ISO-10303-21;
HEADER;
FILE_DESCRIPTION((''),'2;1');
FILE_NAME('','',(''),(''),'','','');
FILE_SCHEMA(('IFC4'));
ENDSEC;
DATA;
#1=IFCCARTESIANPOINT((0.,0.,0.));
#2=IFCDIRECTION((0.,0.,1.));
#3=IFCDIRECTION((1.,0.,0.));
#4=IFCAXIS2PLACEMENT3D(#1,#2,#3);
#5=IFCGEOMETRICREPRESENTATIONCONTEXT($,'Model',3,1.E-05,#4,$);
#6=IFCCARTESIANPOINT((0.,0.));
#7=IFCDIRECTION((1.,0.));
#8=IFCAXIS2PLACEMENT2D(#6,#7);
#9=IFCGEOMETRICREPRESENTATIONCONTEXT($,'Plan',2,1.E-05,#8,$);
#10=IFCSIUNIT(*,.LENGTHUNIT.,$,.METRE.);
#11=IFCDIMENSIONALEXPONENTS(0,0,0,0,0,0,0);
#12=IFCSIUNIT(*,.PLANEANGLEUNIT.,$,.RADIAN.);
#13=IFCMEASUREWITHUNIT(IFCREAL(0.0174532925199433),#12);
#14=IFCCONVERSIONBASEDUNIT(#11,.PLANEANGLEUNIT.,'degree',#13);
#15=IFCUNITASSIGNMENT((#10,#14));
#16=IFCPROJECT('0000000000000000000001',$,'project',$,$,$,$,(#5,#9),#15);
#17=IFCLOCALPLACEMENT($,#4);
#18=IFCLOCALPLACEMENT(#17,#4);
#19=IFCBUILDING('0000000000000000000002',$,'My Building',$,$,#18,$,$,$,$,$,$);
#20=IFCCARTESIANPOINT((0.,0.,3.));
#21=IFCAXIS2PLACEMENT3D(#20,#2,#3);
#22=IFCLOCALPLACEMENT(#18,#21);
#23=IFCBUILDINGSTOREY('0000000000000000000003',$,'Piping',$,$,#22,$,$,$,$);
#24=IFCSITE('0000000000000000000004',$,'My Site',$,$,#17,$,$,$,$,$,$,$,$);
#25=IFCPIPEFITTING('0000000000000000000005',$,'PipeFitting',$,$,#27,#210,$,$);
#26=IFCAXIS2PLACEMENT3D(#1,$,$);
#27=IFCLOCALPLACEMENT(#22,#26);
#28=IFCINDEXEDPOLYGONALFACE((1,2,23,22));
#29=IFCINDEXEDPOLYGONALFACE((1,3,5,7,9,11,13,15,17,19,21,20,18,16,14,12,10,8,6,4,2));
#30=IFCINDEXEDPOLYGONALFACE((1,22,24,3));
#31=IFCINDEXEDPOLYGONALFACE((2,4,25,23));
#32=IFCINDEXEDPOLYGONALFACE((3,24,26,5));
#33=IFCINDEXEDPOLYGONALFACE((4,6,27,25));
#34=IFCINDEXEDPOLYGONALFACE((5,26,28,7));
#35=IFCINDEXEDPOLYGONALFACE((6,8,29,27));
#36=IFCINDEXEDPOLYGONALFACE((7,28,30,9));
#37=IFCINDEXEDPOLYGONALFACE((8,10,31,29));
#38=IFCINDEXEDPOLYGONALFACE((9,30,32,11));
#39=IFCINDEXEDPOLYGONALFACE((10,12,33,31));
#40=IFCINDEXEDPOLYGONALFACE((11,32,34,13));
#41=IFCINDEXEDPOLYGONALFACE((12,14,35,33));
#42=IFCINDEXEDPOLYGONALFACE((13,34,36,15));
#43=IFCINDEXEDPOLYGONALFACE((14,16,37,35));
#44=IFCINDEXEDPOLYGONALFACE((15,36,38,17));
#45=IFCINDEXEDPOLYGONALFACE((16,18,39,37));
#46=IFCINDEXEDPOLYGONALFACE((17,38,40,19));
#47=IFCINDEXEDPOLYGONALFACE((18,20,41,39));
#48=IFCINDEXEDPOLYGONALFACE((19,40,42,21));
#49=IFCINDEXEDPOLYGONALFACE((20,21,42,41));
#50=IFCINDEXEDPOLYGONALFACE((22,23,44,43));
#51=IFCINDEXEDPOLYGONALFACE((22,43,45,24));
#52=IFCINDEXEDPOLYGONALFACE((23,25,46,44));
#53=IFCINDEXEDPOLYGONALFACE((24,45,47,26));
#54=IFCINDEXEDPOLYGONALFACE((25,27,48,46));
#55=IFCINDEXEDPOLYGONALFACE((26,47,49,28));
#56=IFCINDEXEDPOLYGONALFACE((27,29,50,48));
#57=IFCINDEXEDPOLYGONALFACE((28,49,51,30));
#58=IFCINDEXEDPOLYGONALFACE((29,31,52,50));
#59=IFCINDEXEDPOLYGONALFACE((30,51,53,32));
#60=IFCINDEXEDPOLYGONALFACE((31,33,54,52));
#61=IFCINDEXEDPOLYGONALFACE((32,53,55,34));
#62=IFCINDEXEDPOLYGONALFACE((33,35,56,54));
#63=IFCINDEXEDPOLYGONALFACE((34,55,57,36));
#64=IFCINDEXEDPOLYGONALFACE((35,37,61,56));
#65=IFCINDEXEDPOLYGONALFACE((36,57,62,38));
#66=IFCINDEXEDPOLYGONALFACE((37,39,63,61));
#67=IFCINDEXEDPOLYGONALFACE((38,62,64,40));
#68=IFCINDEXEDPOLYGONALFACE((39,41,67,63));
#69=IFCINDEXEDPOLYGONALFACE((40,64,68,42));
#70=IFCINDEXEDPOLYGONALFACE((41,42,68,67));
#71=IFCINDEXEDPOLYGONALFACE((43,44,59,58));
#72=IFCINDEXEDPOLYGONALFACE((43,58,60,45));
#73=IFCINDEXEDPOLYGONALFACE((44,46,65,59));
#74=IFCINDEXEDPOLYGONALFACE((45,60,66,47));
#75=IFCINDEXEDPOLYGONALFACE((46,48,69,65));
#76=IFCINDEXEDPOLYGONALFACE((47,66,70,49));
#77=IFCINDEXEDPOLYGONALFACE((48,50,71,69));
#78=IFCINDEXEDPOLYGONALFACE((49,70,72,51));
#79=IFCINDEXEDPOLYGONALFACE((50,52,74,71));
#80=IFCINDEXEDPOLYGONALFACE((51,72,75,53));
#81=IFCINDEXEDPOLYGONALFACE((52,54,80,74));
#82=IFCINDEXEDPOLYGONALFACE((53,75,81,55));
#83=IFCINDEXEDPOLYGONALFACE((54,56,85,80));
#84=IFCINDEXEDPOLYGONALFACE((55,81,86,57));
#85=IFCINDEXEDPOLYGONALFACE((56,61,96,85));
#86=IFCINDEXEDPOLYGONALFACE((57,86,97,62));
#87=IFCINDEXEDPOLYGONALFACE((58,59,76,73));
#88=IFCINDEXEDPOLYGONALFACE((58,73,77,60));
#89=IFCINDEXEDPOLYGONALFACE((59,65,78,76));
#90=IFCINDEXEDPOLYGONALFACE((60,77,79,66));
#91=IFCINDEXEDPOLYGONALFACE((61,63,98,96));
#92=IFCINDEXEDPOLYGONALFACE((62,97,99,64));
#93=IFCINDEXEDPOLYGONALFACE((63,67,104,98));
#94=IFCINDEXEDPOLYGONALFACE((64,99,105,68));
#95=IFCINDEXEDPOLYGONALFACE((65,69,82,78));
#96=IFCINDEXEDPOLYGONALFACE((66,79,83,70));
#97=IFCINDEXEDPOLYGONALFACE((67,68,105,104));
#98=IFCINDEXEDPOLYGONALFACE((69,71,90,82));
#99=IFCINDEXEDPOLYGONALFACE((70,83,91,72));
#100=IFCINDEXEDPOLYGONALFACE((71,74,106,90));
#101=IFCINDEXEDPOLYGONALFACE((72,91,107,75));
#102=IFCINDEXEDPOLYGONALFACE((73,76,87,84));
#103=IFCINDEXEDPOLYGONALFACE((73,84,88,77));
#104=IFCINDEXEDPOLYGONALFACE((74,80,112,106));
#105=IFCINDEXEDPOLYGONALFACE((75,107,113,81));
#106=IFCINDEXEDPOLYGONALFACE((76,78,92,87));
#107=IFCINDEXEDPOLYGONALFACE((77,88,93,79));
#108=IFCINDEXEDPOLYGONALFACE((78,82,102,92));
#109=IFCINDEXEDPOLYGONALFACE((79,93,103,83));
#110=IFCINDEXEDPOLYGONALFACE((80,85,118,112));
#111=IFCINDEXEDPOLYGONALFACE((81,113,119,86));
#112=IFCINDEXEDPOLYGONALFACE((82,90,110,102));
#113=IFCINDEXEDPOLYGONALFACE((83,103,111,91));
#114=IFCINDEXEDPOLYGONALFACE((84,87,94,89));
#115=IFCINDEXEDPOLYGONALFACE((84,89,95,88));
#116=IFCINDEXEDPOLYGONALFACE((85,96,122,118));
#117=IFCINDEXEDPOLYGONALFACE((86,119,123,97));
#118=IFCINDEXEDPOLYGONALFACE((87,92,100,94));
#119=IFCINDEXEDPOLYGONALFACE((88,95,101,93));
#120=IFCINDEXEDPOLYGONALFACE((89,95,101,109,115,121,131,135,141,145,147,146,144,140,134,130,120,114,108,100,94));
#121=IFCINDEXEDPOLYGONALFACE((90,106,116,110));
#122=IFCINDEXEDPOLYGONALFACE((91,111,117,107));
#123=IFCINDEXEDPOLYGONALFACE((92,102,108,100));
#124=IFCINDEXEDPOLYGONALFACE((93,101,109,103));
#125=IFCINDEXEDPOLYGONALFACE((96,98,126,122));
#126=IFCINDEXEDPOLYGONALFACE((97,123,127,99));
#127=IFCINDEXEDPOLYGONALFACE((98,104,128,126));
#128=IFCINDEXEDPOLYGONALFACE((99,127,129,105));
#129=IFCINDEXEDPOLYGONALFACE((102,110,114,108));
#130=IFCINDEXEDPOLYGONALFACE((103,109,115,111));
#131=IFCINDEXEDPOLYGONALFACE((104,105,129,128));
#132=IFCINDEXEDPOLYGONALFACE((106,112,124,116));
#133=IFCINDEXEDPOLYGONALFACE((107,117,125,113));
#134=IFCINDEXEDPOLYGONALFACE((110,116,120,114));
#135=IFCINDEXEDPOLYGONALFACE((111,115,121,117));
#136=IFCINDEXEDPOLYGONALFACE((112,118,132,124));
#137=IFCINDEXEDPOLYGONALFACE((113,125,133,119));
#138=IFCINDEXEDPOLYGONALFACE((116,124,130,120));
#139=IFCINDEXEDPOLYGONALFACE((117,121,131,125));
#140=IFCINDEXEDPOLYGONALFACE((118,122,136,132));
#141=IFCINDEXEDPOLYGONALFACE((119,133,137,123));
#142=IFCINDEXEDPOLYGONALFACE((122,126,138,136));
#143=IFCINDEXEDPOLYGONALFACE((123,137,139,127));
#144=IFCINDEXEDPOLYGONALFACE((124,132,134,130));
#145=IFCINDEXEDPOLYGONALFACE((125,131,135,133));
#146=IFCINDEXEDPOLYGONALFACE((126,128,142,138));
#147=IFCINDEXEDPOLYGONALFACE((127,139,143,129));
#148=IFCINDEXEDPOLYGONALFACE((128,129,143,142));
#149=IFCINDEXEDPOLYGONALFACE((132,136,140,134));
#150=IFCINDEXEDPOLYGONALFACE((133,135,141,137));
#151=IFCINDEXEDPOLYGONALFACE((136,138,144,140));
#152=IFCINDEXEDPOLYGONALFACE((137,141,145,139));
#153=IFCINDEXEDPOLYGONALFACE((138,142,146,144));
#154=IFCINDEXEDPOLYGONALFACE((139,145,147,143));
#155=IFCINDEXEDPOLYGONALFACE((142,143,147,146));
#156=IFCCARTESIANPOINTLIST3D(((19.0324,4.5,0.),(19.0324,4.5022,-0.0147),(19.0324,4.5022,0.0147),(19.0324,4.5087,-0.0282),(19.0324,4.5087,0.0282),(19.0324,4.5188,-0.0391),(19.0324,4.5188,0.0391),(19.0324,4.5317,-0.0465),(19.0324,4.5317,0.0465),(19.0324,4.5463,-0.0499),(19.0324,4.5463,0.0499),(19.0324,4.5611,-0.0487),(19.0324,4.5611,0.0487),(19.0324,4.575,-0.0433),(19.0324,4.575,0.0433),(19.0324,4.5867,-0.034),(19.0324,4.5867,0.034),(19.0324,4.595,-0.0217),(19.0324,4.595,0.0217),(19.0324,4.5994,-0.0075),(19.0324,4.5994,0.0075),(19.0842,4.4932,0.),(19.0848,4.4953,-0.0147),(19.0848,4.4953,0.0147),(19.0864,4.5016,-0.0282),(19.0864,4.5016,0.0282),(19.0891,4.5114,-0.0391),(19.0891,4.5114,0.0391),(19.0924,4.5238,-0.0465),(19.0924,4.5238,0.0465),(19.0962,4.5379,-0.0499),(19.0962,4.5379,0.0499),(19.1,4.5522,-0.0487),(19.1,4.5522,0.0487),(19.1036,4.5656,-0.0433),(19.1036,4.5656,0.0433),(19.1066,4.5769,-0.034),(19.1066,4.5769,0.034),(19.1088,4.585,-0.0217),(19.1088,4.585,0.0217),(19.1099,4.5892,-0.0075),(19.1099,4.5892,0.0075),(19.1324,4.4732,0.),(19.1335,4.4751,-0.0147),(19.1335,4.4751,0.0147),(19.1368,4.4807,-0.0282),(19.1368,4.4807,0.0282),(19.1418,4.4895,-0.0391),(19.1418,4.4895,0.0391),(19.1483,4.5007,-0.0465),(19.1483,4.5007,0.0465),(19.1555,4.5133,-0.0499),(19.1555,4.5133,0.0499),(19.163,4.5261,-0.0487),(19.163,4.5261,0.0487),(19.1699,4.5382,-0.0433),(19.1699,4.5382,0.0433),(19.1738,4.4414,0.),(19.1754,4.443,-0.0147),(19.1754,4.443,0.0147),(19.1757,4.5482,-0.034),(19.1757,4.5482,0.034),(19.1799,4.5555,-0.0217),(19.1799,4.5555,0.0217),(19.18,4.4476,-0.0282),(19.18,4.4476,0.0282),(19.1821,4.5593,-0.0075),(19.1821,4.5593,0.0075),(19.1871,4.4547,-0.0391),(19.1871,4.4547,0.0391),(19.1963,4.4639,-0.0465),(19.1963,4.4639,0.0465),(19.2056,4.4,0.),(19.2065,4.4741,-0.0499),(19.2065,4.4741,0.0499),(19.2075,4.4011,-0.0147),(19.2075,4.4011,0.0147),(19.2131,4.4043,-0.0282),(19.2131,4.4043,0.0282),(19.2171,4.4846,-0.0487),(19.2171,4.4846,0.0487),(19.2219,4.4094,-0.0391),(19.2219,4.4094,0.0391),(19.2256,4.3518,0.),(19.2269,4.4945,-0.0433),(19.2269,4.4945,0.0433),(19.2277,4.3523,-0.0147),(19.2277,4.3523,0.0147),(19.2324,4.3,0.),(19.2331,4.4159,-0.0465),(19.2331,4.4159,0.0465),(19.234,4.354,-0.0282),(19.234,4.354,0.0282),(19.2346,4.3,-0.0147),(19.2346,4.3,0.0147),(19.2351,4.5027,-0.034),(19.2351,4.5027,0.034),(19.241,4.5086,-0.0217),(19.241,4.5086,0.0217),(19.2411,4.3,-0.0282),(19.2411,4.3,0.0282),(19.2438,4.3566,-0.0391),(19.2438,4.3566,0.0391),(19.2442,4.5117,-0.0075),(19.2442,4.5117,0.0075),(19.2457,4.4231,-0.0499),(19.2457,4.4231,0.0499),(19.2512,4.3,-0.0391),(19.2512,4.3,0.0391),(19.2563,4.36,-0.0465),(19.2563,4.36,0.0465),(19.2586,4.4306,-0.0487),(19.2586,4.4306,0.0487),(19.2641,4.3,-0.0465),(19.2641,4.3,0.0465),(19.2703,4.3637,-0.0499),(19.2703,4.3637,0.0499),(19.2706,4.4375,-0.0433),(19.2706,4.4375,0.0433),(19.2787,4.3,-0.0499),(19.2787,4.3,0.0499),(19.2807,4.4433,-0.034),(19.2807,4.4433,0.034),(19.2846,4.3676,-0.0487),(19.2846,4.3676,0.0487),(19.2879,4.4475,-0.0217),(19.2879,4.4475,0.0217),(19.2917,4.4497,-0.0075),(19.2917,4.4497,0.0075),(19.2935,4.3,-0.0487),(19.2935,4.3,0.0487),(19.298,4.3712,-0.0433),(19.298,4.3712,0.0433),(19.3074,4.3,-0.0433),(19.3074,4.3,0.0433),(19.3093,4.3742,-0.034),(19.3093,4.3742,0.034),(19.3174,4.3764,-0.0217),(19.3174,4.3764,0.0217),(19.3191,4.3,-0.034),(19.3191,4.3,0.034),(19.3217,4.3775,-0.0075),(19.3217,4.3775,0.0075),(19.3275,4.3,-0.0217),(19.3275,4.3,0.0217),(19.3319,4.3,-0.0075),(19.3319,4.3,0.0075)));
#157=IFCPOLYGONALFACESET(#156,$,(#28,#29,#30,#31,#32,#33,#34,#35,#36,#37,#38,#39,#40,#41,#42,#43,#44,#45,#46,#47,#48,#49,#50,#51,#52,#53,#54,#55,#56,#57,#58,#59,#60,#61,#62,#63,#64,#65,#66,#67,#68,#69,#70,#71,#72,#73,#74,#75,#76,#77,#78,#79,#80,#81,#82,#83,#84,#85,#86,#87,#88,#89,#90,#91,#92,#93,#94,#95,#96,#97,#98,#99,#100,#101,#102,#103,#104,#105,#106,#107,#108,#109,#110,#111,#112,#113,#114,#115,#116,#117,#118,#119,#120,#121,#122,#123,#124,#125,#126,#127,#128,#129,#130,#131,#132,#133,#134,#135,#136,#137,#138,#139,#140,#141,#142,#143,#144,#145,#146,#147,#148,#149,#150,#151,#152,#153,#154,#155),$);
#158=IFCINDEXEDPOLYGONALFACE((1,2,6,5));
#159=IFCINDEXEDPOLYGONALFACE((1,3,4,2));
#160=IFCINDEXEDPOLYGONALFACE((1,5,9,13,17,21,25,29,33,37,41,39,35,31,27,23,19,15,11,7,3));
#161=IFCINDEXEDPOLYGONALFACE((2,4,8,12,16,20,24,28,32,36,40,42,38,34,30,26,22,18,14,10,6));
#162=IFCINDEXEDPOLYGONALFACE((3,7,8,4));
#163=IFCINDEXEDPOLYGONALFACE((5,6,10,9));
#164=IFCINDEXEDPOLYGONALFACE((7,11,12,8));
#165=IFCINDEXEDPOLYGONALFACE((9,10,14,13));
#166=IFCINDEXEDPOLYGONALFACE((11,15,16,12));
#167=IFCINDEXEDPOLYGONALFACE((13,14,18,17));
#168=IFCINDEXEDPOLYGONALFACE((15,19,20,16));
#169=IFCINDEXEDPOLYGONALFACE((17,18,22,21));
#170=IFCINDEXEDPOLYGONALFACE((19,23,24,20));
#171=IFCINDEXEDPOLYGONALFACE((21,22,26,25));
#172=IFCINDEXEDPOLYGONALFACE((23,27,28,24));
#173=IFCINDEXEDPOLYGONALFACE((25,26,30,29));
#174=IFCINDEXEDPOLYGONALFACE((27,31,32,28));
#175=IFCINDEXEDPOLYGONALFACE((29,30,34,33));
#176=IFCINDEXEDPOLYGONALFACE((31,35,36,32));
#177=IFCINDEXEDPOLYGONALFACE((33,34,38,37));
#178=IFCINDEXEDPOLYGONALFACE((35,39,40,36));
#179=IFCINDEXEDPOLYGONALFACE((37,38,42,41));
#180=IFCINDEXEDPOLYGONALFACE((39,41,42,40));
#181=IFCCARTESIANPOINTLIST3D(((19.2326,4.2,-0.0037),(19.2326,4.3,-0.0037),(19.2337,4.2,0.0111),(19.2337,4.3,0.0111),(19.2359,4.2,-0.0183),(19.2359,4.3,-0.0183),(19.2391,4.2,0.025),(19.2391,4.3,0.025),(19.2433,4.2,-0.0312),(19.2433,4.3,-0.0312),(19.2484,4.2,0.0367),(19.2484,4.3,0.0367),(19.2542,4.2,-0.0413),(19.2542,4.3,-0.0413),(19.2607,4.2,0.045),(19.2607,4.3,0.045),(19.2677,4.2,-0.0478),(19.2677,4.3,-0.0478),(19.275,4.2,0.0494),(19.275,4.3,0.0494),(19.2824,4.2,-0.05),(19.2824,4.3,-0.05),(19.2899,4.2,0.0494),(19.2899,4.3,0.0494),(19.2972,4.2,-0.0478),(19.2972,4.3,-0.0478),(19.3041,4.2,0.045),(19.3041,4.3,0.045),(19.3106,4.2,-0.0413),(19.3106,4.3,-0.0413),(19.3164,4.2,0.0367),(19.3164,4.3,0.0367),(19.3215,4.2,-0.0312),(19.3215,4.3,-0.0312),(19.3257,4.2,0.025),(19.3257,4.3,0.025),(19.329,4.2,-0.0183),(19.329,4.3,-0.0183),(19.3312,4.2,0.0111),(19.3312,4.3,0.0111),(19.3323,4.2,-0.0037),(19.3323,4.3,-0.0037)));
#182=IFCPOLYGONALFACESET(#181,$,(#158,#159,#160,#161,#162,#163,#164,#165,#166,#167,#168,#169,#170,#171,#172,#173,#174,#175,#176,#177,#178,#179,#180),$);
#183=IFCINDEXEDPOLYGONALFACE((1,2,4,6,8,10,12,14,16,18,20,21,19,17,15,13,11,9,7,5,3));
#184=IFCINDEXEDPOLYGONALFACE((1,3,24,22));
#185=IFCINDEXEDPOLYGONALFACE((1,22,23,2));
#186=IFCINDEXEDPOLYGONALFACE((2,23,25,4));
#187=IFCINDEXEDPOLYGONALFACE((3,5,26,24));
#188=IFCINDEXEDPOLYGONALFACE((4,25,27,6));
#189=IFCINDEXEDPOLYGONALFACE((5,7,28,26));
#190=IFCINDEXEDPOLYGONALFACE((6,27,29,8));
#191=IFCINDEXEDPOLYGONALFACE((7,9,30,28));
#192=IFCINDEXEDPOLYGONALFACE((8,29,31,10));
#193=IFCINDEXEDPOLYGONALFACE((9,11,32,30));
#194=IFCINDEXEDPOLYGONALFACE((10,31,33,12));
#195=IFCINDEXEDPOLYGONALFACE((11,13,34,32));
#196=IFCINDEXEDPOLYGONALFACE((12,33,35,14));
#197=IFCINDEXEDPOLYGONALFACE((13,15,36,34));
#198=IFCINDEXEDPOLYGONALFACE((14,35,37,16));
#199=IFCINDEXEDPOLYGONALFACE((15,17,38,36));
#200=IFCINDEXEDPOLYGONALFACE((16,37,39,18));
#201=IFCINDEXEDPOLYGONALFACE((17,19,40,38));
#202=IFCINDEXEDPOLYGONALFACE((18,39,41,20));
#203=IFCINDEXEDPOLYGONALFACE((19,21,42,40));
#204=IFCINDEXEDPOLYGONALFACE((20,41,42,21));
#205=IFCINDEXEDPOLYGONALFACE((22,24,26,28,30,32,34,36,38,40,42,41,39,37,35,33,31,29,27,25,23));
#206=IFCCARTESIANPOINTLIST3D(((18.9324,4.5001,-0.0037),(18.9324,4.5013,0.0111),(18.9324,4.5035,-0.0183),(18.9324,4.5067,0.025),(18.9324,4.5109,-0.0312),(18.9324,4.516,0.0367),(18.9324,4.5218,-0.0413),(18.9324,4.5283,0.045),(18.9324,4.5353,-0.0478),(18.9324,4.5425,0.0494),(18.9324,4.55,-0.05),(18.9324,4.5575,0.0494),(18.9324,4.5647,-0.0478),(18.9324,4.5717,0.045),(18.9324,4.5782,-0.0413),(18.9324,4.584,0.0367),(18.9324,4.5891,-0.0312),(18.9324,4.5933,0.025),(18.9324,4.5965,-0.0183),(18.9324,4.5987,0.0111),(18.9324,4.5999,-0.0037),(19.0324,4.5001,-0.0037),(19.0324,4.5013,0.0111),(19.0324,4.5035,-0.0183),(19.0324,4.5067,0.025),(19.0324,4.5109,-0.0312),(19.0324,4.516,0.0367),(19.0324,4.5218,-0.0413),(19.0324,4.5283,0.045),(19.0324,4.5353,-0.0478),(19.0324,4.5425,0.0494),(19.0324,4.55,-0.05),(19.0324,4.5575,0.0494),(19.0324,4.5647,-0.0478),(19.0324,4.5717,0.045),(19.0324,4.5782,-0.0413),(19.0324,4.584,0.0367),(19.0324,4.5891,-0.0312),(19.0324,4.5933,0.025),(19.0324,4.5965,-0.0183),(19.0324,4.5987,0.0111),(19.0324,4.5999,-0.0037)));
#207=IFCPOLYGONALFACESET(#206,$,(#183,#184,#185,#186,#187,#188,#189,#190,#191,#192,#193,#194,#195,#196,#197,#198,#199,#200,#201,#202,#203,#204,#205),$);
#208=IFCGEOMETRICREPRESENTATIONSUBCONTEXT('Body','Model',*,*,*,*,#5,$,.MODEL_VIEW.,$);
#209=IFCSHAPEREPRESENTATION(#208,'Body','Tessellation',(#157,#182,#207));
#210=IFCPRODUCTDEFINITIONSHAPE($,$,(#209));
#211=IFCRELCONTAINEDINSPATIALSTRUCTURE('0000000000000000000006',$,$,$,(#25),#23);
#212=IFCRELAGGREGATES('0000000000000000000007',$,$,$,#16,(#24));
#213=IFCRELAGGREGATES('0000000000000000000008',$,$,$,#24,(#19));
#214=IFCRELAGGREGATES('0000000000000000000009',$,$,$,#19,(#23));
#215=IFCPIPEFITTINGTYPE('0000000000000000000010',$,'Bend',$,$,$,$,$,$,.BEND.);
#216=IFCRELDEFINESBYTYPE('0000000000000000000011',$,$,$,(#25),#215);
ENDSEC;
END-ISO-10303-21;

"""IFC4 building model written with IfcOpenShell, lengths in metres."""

from ifc_helpers import new_model, entity, si_unit, converted_unit, frame, origin_with_axes, origin_2d_with_axis, place, context, subcontext, project, spatial, circle, extrude, source, transform, mapped, type_object, type_shapes, element, save


model = new_model("IFC4")

# Units and contexts
model_context = context("Model", 3, precision=1e-05, world=origin_with_axes())
plan_context = context("Plan", 2, precision=1e-05, world=origin_2d_with_axis())
body_context = subcontext(model_context, "Body", "Model", "MODEL_VIEW")
ifc_project = project(units=[si_unit("LENGTHUNIT", "METRE"), converted_unit("PLANEANGLEUNIT", "degree", entity("IfcReal", 0.0174532925199433), si_unit("PLANEANGLEUNIT", "RADIAN"), dimensions=[0, 0, 0, 0, 0, 0, 0])], contexts=[model_context, plan_context])

# Site, building, storey
site_placement = place(None, origin_with_axes())
site = spatial("IfcSite", under=ifc_project, at=site_placement, Name="My Site")
building_placement = place(site_placement, origin_with_axes())
building = spatial("IfcBuilding", under=site, at=building_placement, Name="My Building")
storey_placement = place(building_placement, frame((0.0, 0.0, 3.0), z_axis=(0.0, 0.0, 1.0), x_axis=(1.0, 0.0, 0.0)))
storey = spatial("IfcBuildingStorey", under=building, at=storey_placement, Name="Piping")

# Pipe fitting
pipe_fitting_type_1 = type_object("IfcPipeFittingType", Name="Bend", PredefinedType="BEND")
shared_shape = source(origin_with_axes(), body_context, "Body", "SolidModel", [
    entity("IfcSweptDiskSolid", entity("IfcIndexedPolyCurve", entity("IfcCartesianPointList3D", [[0.0, 0.0, -0.1], [0.0, -0.0732, -0.2768], [0.0, -0.25, -0.35]]), [entity("IfcArcIndex", [1, 2, 3])]), 0.05),
    extrude(circle(Radius=0.05), origin_with_axes(), (0.0, 0.0, -1.0), 0.1),
    extrude(circle(Radius=0.05), frame((0.0, -0.25, -0.35), z_axis=(0.0, -1.0, 0.0), x_axis=(1.0, 0.0, 0.0)), (0.0, 0.0, 1.0), 0.1),
])
type_shapes(pipe_fitting_type_1, [shared_shape])
for number, where, z_axis, x_axis, name in (
    (1, (19.2824, 4.2, 0.0), (0.0, -1.0, 0.0), (0.0, 0.0, -1.0), "PipeFitting"),
):
    element("IfcPipeFitting", number, at=place(storey_placement, frame(where, z_axis=z_axis, x_axis=x_axis)), inside=storey, type_object=pipe_fitting_type_1, Name=name, context=body_context, shape_type="MappedRepresentation", body=[
        mapped(shared_shape, transform((0.0, 0.0, 0.0), x_axis=(1.0, 0.0, 0.0), y_axis=(0.0, 1.0, 0.0), z_axis=(0.0, 0.0, 1.0), scale=1.0)),
    ])

save(model, "model.ifc")
